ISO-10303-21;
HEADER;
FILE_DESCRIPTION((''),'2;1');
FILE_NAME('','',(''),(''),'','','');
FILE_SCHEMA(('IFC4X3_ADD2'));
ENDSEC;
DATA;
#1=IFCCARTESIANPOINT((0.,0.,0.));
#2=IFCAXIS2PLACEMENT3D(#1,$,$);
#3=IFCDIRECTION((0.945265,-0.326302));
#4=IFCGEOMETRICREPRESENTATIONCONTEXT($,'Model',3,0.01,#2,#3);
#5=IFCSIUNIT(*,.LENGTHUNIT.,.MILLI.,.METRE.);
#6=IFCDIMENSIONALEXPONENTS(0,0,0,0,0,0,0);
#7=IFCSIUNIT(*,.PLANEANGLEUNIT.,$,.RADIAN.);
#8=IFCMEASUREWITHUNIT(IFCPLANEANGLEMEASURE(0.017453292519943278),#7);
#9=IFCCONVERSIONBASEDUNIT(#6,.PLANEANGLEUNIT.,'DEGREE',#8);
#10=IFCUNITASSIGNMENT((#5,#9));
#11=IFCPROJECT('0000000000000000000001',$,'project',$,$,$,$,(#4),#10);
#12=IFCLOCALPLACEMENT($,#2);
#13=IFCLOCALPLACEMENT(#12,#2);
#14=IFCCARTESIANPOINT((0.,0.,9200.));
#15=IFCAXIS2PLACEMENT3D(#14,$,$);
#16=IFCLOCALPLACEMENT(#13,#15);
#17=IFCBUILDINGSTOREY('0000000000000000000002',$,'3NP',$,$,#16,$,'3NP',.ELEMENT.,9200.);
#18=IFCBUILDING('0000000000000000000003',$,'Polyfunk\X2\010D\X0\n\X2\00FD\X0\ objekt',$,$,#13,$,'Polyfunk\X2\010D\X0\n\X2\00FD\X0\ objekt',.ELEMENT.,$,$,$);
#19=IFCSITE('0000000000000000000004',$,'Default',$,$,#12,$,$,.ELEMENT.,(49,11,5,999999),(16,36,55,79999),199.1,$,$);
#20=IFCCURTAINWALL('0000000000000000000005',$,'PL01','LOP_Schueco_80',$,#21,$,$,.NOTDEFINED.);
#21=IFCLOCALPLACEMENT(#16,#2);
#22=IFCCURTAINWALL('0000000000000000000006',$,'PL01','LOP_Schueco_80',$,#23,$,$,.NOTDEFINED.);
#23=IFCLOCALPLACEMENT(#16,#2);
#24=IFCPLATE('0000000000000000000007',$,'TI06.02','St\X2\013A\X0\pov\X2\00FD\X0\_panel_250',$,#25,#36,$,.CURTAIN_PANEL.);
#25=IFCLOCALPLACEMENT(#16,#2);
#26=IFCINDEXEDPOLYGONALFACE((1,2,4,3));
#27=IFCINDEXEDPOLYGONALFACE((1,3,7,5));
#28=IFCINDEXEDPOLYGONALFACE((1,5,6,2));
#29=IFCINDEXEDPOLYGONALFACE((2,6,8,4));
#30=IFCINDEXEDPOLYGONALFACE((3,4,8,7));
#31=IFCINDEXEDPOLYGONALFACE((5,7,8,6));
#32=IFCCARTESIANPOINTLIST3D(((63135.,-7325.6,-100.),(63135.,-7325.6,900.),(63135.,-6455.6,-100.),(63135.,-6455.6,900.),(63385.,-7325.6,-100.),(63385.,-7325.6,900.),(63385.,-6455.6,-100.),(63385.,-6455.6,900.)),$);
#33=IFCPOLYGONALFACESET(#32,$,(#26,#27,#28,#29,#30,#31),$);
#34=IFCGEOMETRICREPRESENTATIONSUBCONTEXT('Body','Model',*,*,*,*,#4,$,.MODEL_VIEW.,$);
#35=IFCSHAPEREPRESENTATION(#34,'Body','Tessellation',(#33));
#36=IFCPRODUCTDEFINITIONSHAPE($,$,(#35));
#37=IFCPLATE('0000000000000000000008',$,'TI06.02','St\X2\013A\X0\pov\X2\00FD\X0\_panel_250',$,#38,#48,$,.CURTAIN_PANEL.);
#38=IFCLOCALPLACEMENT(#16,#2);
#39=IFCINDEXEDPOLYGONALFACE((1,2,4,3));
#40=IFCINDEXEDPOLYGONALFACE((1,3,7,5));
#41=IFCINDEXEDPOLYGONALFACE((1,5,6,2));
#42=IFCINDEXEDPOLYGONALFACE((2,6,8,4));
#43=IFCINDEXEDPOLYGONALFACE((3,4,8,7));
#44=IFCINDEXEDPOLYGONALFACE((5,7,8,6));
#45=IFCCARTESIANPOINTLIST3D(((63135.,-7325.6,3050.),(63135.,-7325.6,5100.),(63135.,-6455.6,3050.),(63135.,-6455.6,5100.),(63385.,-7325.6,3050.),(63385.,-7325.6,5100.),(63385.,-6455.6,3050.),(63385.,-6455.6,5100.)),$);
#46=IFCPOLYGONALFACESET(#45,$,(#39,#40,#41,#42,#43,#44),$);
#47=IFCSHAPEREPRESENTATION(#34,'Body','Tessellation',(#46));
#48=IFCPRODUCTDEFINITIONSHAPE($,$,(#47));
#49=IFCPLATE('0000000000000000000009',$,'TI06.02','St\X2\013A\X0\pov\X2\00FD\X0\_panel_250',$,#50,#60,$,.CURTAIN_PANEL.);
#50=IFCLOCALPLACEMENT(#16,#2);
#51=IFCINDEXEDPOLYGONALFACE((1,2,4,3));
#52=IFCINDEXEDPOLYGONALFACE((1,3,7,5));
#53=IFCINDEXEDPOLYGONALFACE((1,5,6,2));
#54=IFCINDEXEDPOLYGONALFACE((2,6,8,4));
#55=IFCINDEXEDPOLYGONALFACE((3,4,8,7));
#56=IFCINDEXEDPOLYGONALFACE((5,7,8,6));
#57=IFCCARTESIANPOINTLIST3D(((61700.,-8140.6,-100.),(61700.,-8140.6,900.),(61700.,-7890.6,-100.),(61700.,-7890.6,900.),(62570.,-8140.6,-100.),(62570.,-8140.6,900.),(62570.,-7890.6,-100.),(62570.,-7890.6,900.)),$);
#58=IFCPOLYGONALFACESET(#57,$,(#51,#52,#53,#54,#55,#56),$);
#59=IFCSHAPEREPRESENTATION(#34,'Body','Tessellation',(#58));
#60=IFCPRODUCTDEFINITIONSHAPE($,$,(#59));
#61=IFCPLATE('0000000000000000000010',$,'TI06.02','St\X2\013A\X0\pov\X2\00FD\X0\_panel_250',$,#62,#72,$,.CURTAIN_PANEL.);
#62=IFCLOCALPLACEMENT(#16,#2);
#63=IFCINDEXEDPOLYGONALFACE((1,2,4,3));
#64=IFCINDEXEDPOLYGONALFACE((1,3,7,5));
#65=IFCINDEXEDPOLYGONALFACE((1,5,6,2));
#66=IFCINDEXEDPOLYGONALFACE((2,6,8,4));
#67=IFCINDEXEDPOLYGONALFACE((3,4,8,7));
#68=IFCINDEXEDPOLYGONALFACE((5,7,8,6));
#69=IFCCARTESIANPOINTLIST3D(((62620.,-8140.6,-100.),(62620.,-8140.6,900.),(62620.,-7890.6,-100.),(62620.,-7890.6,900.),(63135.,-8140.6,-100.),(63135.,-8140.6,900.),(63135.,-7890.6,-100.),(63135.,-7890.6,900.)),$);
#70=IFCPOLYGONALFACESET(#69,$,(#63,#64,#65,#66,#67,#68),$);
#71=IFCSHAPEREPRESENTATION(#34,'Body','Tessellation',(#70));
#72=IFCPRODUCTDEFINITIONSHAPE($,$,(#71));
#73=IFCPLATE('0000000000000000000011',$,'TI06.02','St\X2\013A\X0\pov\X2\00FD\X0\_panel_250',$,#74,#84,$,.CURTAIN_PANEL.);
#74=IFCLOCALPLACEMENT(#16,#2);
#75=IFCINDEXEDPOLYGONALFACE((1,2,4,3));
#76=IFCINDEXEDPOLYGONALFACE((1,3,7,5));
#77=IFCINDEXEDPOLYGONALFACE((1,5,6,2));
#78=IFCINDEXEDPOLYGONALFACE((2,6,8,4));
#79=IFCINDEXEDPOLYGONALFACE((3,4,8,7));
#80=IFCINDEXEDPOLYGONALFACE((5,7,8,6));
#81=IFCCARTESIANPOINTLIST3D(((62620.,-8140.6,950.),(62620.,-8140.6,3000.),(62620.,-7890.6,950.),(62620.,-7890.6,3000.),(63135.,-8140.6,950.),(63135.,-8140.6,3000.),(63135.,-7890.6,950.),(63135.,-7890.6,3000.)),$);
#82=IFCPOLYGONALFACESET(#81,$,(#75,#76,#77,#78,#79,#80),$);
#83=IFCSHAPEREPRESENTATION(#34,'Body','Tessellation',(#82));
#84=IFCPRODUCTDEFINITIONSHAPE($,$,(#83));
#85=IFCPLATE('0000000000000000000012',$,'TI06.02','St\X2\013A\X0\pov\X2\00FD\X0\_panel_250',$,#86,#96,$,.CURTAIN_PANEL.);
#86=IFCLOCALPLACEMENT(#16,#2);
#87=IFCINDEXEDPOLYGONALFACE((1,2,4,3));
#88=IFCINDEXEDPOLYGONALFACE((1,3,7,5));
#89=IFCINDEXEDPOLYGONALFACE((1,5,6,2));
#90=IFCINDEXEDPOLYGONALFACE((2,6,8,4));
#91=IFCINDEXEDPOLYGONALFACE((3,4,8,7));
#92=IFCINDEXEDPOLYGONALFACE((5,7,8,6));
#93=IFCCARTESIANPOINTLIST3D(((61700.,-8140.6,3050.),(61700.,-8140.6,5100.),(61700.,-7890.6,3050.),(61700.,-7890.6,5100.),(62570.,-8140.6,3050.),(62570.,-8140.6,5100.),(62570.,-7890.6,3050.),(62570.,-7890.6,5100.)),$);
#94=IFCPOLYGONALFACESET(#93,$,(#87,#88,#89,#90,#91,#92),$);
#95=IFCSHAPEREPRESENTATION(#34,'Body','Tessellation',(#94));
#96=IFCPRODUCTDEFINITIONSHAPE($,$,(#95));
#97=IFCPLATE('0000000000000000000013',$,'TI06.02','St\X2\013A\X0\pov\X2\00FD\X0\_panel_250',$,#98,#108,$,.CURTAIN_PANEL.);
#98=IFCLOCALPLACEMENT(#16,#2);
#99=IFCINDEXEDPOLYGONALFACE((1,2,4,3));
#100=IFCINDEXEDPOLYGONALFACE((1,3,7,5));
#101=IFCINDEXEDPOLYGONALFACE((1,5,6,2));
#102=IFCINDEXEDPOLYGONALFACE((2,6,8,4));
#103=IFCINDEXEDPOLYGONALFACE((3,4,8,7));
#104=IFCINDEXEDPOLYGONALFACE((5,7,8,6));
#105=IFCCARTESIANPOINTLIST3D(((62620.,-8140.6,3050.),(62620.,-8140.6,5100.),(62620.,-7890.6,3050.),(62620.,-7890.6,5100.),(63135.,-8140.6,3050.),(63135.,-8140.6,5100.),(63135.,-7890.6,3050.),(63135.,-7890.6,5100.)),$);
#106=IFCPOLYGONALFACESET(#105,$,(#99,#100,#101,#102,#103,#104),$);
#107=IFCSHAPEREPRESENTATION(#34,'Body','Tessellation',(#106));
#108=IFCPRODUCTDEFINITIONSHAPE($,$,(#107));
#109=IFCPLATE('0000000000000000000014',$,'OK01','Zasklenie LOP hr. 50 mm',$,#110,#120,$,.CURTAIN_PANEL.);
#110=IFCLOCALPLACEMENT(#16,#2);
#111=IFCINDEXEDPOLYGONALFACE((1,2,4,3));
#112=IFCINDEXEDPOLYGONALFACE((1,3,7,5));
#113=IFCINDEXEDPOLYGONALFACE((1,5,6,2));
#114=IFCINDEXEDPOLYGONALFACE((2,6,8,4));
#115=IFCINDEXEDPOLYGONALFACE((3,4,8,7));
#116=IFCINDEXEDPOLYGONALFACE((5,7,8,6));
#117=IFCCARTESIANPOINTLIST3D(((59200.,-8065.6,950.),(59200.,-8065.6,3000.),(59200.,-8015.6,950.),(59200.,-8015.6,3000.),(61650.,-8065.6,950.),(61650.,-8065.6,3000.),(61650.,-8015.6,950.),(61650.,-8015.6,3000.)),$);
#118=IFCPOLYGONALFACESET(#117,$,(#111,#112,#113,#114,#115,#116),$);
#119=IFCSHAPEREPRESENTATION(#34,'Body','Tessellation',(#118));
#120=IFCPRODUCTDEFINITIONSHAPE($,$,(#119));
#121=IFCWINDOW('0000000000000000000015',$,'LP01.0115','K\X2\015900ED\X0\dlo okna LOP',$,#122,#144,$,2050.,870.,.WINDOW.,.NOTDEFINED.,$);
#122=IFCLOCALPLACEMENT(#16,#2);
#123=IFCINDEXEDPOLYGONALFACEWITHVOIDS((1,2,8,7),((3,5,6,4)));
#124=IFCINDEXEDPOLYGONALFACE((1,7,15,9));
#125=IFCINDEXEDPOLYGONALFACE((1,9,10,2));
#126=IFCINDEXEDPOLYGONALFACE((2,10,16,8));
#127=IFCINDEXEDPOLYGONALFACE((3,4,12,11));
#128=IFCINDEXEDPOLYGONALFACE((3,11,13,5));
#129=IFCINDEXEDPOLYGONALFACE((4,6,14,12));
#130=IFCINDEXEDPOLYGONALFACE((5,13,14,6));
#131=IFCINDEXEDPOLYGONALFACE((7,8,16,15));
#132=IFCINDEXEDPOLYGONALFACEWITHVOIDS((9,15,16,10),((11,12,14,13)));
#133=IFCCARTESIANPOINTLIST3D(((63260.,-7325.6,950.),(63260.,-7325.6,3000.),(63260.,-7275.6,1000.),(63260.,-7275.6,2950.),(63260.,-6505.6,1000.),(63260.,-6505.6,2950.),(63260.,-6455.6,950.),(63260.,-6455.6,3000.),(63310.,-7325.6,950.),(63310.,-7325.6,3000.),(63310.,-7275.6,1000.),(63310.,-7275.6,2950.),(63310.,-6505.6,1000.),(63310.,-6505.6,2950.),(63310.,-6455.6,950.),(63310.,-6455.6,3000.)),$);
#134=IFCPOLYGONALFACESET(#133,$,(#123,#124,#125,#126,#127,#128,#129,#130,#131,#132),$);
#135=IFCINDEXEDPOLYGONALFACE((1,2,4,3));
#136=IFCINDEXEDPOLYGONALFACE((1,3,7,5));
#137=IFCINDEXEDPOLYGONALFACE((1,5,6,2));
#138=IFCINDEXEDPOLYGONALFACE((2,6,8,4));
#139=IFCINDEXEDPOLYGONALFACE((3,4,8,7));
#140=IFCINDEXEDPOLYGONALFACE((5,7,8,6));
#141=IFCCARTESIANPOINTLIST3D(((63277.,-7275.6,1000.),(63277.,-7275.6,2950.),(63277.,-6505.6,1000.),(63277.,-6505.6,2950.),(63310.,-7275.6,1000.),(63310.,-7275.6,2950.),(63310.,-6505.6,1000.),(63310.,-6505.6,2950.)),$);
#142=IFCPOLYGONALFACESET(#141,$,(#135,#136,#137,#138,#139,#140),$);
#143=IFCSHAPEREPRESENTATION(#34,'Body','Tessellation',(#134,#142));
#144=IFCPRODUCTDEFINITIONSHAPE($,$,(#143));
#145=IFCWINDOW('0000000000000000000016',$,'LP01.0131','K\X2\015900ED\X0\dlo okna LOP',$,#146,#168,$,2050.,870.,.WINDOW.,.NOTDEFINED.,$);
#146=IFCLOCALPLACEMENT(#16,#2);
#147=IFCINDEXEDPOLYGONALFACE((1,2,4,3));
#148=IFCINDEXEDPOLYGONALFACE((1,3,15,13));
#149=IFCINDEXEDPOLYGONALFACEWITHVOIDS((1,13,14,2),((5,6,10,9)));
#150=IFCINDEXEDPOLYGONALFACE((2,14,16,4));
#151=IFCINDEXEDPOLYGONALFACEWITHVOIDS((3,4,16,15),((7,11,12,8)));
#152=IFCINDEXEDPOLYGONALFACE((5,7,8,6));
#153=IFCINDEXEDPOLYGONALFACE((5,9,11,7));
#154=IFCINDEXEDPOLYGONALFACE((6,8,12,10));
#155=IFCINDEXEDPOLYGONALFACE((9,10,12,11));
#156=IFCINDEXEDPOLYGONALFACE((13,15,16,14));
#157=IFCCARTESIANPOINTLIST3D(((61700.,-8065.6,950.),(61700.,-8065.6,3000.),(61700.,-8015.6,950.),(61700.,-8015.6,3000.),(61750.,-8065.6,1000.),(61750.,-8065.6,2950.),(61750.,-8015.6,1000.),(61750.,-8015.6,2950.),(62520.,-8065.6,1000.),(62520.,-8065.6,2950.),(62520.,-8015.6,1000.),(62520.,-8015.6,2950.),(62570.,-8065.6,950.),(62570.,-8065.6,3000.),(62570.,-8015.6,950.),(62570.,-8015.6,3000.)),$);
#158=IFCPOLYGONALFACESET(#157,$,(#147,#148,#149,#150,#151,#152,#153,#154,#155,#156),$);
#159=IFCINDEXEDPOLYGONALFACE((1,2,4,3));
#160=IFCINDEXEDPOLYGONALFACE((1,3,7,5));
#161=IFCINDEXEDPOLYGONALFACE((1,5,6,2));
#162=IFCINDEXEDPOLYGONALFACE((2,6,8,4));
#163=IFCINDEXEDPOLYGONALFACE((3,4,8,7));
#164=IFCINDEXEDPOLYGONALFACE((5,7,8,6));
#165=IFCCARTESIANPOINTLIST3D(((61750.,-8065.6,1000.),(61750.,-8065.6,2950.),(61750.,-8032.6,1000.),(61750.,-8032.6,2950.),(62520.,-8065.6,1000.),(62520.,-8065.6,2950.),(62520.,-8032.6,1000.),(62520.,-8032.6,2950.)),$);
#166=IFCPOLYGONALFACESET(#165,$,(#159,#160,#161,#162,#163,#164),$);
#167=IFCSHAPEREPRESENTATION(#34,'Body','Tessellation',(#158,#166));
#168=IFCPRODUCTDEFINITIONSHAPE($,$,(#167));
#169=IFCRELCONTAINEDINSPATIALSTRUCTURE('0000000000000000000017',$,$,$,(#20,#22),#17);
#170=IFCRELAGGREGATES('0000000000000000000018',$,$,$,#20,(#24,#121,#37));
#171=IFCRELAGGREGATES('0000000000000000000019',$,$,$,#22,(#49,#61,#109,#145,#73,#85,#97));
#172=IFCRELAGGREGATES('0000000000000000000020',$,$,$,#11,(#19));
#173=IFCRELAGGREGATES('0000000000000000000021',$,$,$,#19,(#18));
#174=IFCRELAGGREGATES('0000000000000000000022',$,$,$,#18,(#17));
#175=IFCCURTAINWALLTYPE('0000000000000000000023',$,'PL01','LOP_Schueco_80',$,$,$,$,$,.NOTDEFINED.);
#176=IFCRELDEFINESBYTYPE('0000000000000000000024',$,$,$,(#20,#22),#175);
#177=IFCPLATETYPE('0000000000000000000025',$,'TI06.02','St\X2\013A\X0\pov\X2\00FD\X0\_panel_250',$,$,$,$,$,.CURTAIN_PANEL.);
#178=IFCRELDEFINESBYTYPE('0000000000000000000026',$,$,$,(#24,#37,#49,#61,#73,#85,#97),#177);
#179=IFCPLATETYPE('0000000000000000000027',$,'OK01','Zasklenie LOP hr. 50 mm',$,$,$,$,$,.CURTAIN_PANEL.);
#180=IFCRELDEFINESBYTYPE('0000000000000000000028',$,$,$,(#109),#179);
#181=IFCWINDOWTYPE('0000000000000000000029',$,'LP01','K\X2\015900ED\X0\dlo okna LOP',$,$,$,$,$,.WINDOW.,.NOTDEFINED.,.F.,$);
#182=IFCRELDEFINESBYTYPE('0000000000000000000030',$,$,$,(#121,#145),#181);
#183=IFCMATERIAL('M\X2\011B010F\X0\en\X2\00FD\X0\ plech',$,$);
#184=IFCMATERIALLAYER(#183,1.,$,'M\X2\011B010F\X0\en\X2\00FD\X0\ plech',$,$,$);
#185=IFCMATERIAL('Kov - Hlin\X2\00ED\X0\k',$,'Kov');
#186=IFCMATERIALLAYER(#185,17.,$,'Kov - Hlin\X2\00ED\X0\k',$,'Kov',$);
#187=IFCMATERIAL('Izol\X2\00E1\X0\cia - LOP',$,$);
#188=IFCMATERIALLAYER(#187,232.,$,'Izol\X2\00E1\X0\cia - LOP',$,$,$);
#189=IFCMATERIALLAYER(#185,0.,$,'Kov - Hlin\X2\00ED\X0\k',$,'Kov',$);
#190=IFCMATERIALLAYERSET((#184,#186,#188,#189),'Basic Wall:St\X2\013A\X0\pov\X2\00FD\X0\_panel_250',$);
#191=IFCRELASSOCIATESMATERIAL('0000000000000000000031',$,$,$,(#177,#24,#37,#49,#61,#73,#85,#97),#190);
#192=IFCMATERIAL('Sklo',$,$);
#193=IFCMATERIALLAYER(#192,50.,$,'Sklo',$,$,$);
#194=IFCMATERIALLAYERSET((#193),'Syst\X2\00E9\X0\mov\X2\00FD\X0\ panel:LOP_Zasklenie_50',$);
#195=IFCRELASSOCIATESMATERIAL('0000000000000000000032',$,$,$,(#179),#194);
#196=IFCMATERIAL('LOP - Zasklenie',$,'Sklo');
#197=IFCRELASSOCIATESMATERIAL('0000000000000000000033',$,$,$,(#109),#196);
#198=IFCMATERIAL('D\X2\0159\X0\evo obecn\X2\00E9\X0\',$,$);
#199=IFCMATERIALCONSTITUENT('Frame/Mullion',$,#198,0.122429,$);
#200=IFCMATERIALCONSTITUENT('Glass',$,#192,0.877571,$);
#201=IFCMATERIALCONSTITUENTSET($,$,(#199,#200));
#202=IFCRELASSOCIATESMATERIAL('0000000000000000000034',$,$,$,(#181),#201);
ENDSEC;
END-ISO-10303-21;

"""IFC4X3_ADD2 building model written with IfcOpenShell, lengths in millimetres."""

from ifc_helpers import new_model, entity, si_unit, converted_unit, direction, frame, frame_2d, origin, origin_2d_with_axis, place, context, subcontext, project, spatial, polyline, rectangle, outline, extrude, source, transform, mapped, material, layer, layer_set, layer_usage, constituent, constituent_set, type_object, type_shapes, element, aggregate, save


model = new_model("IFC4X3_ADD2")

# Units and contexts
model_context = context("Model", 3, precision=0.01, world=origin(), true_north=direction((0.945265, -0.326302)))
body_context = subcontext(model_context, "Body", "Model", "MODEL_VIEW")
ifc_project = project(units=[si_unit("LENGTHUNIT", "METRE", prefix="MILLI"), converted_unit("PLANEANGLEUNIT", "DEGREE", entity("IfcPlaneAngleMeasure", 0.017453292519943278), si_unit("PLANEANGLEUNIT", "RADIAN"), dimensions=[0, 0, 0, 0, 0, 0, 0])], contexts=[model_context])

# Site, building, storey
site_placement = place(None, origin())
site = spatial("IfcSite", under=ifc_project, at=site_placement, Name="Default", CompositionType="ELEMENT", RefLatitude=(49, 11, 5, 999999), RefLongitude=(16, 36, 55, 79999), RefElevation=199.1)
building_placement = place(site_placement, origin())
building = spatial("IfcBuilding", under=site, at=building_placement, Name="Polyfunkčný objekt", LongName="Polyfunkčný objekt", CompositionType="ELEMENT")
storey_placement = place(building_placement, frame((0.0, 0.0, 9200.0)))
storey = spatial("IfcBuildingStorey", under=building, at=storey_placement, Name="3NP", LongName="3NP", CompositionType="ELEMENT", Elevation=9200.0)

# Curtain walls
curtain_wall_type = type_object("IfcCurtainWallType", Name="PL01", Description="LOP_Schueco_80", PredefinedType="NOTDEFINED")
curtain_wall_1_placement = place(storey_placement, frame((0.0, 0.0, -9200.0)))
curtain_wall_1 = element("IfcCurtainWall", 1, at=curtain_wall_1_placement, inside=storey, type_object=curtain_wall_type, Name="PL01", Description="LOP_Schueco_80", PredefinedType="NOTDEFINED")
curtain_wall_2_placement = place(storey_placement, frame((0.0, 0.0, -9200.0)))
curtain_wall_2 = element("IfcCurtainWall", 2, at=curtain_wall_2_placement, inside=storey, type_object=curtain_wall_type, Name="PL01", Description="LOP_Schueco_80", PredefinedType="NOTDEFINED")

# Plates
ifc_material_1 = material(Name="Měďený plech")
ifc_layer_1 = layer(ifc_material_1, 1.0, Name="Měďený plech")
ifc_material_2 = material(Name="Kov - Hliník", Category="Kov")
ifc_layer_2 = layer(ifc_material_2, 17.0, Name="Kov - Hliník", Category="Kov")
ifc_material_3 = material(Name="Izolácia - LOP")
ifc_layer_3 = layer(ifc_material_3, 232.0, Name="Izolácia - LOP")
ifc_layer_4 = layer(ifc_material_2, 0.0, Name="Kov - Hliník", Category="Kov")
ifc_layer_set_1 = layer_set([ifc_layer_1, ifc_layer_2, ifc_layer_3, ifc_layer_4], Name="Basic Wall:Stĺpový_panel_250")
ifc_layer_usage_1 = layer_usage(ifc_layer_set_1, "AXIS2", "NEGATIVE", 125.0)
plate_type_1 = type_object("IfcPlateType", Name="TI06.02", Description="Stĺpový_panel_250", PredefinedType="CURTAIN_PANEL", material=ifc_layer_set_1)
plate_1_placement = place(storey_placement, frame((63260.0, -6455.6, -100.0), z_axis=(0.0, 0.0, 1.0), x_axis=(0.0, -1.0, 0.0)))
plate_1 = element("IfcPlate", 3, at=plate_1_placement, type_object=plate_type_1, material=ifc_layer_usage_1, Name="TI06.02", Description="Stĺpový_panel_250", PredefinedType="CURTAIN_PANEL", context=body_context, shape_type="SweptSolid", body=[
    extrude(rectangle(XDim=250.0, YDim=870.0, at=frame_2d((0.0, 0.0), x_axis=(1.0, 0.0))), frame((435.0, 0.0, 0.0), z_axis=(0.0, 0.0, 1.0), x_axis=(0.0, 1.0, 0.0)), (0.0, 0.0, 1.0), 1000.0),
])
ifc_layer_usage_2 = layer_usage(ifc_layer_set_1, "AXIS2", "NEGATIVE", 125.0)
plate_2_placement = place(storey_placement, frame((63260.0, -6455.6, 3050.0), z_axis=(0.0, 0.0, 1.0), x_axis=(0.0, -1.0, 0.0)))
plate_2 = element("IfcPlate", 4, at=plate_2_placement, type_object=plate_type_1, material=ifc_layer_usage_2, Name="TI06.02", Description="Stĺpový_panel_250", PredefinedType="CURTAIN_PANEL", context=body_context, shape_type="SweptSolid", body=[
    extrude(rectangle(XDim=250.0, YDim=870.0, at=frame_2d((0.0, 0.0), x_axis=(1.0, 0.0))), frame((435.0, 0.0, 0.0), z_axis=(0.0, 0.0, 1.0), x_axis=(0.0, 1.0, 0.0)), (0.0, 0.0, 1.0), 2050.0),
])
ifc_layer_usage_3 = layer_usage(ifc_layer_set_1, "AXIS2", "POSITIVE", -125.0)
plate_3_placement = place(storey_placement, frame((61700.0, -8015.6, -100.0)))
plate_3 = element("IfcPlate", 5, at=plate_3_placement, type_object=plate_type_1, material=ifc_layer_usage_3, Name="TI06.02", Description="Stĺpový_panel_250", PredefinedType="CURTAIN_PANEL", context=body_context, shape_type="SweptSolid", body=[
    extrude(rectangle(XDim=250.0, YDim=870.0, at=frame_2d((0.0, 0.0), x_axis=(1.0, 0.0))), frame((435.0, 0.0, 0.0), z_axis=(0.0, 0.0, 1.0), x_axis=(0.0, 1.0, 0.0)), (0.0, 0.0, 1.0), 1000.0),
])
ifc_layer_usage_4 = layer_usage(ifc_layer_set_1, "AXIS2", "POSITIVE", -125.0)
plate_4_placement = place(storey_placement, frame((62620.0, -8015.6, -100.0)))
plate_4 = element("IfcPlate", 6, at=plate_4_placement, type_object=plate_type_1, material=ifc_layer_usage_4, Name="TI06.02", Description="Stĺpový_panel_250", PredefinedType="CURTAIN_PANEL", context=body_context, shape_type="SweptSolid", body=[
    extrude(rectangle(XDim=250.0, YDim=515.0, at=frame_2d((0.0, 0.0), x_axis=(1.0, 0.0))), frame((257.5, 0.0, 0.0), z_axis=(0.0, 0.0, 1.0), x_axis=(0.0, 1.0, 0.0)), (0.0, 0.0, 1.0), 1000.0),
])
ifc_layer_usage_5 = layer_usage(ifc_layer_set_1, "AXIS2", "POSITIVE", -125.0)
plate_5_placement = place(storey_placement, frame((62620.0, -8015.6, 950.0)))
plate_5 = element("IfcPlate", 7, at=plate_5_placement, type_object=plate_type_1, material=ifc_layer_usage_5, Name="TI06.02", Description="Stĺpový_panel_250", PredefinedType="CURTAIN_PANEL", context=body_context, shape_type="SweptSolid", body=[
    extrude(rectangle(XDim=250.0, YDim=515.0, at=frame_2d((0.0, 0.0), x_axis=(1.0, 0.0))), frame((257.5, 0.0, 0.0), z_axis=(0.0, 0.0, 1.0), x_axis=(0.0, 1.0, 0.0)), (0.0, 0.0, 1.0), 2050.0),
])
ifc_layer_usage_6 = layer_usage(ifc_layer_set_1, "AXIS2", "POSITIVE", -125.0)
plate_6_placement = place(storey_placement, frame((61700.0, -8015.6, 3050.0)))
plate_6 = element("IfcPlate", 8, at=plate_6_placement, type_object=plate_type_1, material=ifc_layer_usage_6, Name="TI06.02", Description="Stĺpový_panel_250", PredefinedType="CURTAIN_PANEL", context=body_context, shape_type="SweptSolid", body=[
    extrude(rectangle(XDim=250.0, YDim=870.0, at=frame_2d((0.0, 0.0), x_axis=(1.0, 0.0))), frame((435.0, 0.0, 0.0), z_axis=(0.0, 0.0, 1.0), x_axis=(0.0, 1.0, 0.0)), (0.0, 0.0, 1.0), 2050.0),
])
ifc_layer_usage_7 = layer_usage(ifc_layer_set_1, "AXIS2", "POSITIVE", -125.0)
plate_7_placement = place(storey_placement, frame((62620.0, -8015.6, 3050.0)))
plate_7 = element("IfcPlate", 9, at=plate_7_placement, type_object=plate_type_1, material=ifc_layer_usage_7, Name="TI06.02", Description="Stĺpový_panel_250", PredefinedType="CURTAIN_PANEL", context=body_context, shape_type="SweptSolid", body=[
    extrude(rectangle(XDim=250.0, YDim=515.0, at=frame_2d((0.0, 0.0), x_axis=(1.0, 0.0))), frame((257.5, 0.0, 0.0), z_axis=(0.0, 0.0, 1.0), x_axis=(0.0, 1.0, 0.0)), (0.0, 0.0, 1.0), 2050.0),
])
ifc_material_4 = material(Name="LOP - Zasklenie", Category="Sklo")
ifc_material_5 = material(Name="Sklo")
ifc_layer_5 = layer(ifc_material_5, 50.0, Name="Sklo")
ifc_layer_set_2 = layer_set([ifc_layer_5], Name="Systémový panel:LOP_Zasklenie_50")
plate_type_2 = type_object("IfcPlateType", Name="OK01", Description="Zasklenie LOP hr. 50 mm", PredefinedType="CURTAIN_PANEL", material=ifc_layer_set_2)
shared_shape_1 = source(origin(), body_context, "Body", "SweptSolid", [
    extrude(rectangle(XDim=50.0, YDim=2450.0, at=origin_2d_with_axis()), frame((0.0, -25.0, 0.0), z_axis=(0.0, 0.0, 1.0), x_axis=(0.0, 1.0, 0.0)), (0.0, 0.0, 1.0), 2050.0),
])
type_shapes(plate_type_2, [shared_shape_1])
plate_8_placement = place(curtain_wall_2_placement, frame((60425.0, -8015.6, 10150.0)))
plate_8 = element("IfcPlate", 10, at=plate_8_placement, type_object=plate_type_2, material=ifc_material_4, Name="OK01", Description="Zasklenie LOP hr. 50 mm", PredefinedType="CURTAIN_PANEL", context=body_context, shape_type="MappedRepresentation", body=[
    mapped(shared_shape_1, transform((0.0, 0.0, 0.0), scale=1.0)),
])

# Windows
ifc_material_6 = material(Name="Dřevo obecné")
ifc_constituent_1 = constituent(ifc_material_6, Name="Frame/Mullion", fraction=0.122429)
ifc_constituent_2 = constituent(ifc_material_5, Name="Glass", fraction=0.877571)
ifc_constituent_set = constituent_set(constituents=[ifc_constituent_1, ifc_constituent_2])
window_type = type_object("IfcWindowType", Name="LP01", Description="Křídlo okna LOP", ParameterTakesPrecedence=False, PartitioningType="NOTDEFINED", PredefinedType="WINDOW", material=ifc_constituent_set)
shared_shape_2 = source(origin(), body_context, "Body", "SweptSolid", [
    extrude(outline(polyline([(-1025.0, -435.0), (1025.0, -435.0), (1025.0, 435.0), (-1025.0, 435.0), (-1025.0, -435.0)]), holes=[polyline([(-975.0, -385.0), (-975.0, 385.0), (975.0, 385.0), (975.0, -385.0), (-975.0, -385.0)])]), frame((0.0, 0.0, 1025.0), z_axis=(0.0, 1.0, 0.0), x_axis=(0.0, 0.0, -1.0)), (0.0, 0.0, 1.0), 50.0),
    extrude(rectangle(XDim=33.0, YDim=770.0, at=origin_2d_with_axis()), frame((0.0, 33.5, 50.0), z_axis=(0.0, 0.0, 1.0), x_axis=(0.0, -1.0, 0.0)), (0.0, 0.0, 1.0), 1950.0),
])
window_1_placement = place(curtain_wall_1_placement, frame((63260.0, -6890.6, 10150.0), z_axis=(0.0, 0.0, 1.0), x_axis=(0.0, -1.0, 0.0)))
window_1 = element("IfcWindow", 11, at=window_1_placement, type_object=window_type, Name="LP01.0115", Description="Křídlo okna LOP", OverallHeight=2050.0, OverallWidth=870.0, PartitioningType="NOTDEFINED", PredefinedType="WINDOW", context=body_context, shape_type="MappedRepresentation", body=[
    mapped(shared_shape_2, transform((0.0, 0.0, 0.0), scale=1.0)),
])
aggregate(curtain_wall_1, [plate_1, window_1, plate_2])
shared_shape_3 = source(origin(), body_context, "Body", "SweptSolid", [
    extrude(outline(polyline([(-1025.0, -435.0), (1025.0, -435.0), (1025.0, 435.0), (-1025.0, 435.0), (-1025.0, -435.0)]), holes=[polyline([(-975.0, -385.0), (-975.0, 385.0), (975.0, 385.0), (975.0, -385.0), (-975.0, -385.0)])]), frame((0.0, 50.0, 1025.0), z_axis=(0.0, -1.0, 0.0), x_axis=(0.0, 0.0, -1.0)), (0.0, 0.0, 1.0), 50.0),
    extrude(rectangle(XDim=770.0, YDim=33.0, at=frame_2d((0.0, 0.0), x_axis=(1.0, 0.0))), frame((0.0, 33.5, 50.0), z_axis=(0.0, 0.0, 1.0), x_axis=(-1.0, 0.0, 0.0)), (0.0, 0.0, 1.0), 1950.0),
])
type_shapes(window_type, [shared_shape_2, shared_shape_3])
window_2_placement = place(curtain_wall_2_placement, frame((62135.0, -8015.6, 10150.0), z_axis=(0.0, 0.0, 1.0), x_axis=(-1.0, 0.0, 0.0)))
window_2 = element("IfcWindow", 12, at=window_2_placement, type_object=window_type, Name="LP01.0131", Description="Křídlo okna LOP", OverallHeight=2050.0, OverallWidth=870.0, PartitioningType="NOTDEFINED", PredefinedType="WINDOW", context=body_context, shape_type="MappedRepresentation", body=[
    mapped(shared_shape_3, transform((0.0, 0.0, 0.0), scale=1.0)),
])
aggregate(curtain_wall_2, [plate_3, plate_4, plate_8, window_2, plate_5, plate_6, plate_7])

save(model, "model.ifc")
